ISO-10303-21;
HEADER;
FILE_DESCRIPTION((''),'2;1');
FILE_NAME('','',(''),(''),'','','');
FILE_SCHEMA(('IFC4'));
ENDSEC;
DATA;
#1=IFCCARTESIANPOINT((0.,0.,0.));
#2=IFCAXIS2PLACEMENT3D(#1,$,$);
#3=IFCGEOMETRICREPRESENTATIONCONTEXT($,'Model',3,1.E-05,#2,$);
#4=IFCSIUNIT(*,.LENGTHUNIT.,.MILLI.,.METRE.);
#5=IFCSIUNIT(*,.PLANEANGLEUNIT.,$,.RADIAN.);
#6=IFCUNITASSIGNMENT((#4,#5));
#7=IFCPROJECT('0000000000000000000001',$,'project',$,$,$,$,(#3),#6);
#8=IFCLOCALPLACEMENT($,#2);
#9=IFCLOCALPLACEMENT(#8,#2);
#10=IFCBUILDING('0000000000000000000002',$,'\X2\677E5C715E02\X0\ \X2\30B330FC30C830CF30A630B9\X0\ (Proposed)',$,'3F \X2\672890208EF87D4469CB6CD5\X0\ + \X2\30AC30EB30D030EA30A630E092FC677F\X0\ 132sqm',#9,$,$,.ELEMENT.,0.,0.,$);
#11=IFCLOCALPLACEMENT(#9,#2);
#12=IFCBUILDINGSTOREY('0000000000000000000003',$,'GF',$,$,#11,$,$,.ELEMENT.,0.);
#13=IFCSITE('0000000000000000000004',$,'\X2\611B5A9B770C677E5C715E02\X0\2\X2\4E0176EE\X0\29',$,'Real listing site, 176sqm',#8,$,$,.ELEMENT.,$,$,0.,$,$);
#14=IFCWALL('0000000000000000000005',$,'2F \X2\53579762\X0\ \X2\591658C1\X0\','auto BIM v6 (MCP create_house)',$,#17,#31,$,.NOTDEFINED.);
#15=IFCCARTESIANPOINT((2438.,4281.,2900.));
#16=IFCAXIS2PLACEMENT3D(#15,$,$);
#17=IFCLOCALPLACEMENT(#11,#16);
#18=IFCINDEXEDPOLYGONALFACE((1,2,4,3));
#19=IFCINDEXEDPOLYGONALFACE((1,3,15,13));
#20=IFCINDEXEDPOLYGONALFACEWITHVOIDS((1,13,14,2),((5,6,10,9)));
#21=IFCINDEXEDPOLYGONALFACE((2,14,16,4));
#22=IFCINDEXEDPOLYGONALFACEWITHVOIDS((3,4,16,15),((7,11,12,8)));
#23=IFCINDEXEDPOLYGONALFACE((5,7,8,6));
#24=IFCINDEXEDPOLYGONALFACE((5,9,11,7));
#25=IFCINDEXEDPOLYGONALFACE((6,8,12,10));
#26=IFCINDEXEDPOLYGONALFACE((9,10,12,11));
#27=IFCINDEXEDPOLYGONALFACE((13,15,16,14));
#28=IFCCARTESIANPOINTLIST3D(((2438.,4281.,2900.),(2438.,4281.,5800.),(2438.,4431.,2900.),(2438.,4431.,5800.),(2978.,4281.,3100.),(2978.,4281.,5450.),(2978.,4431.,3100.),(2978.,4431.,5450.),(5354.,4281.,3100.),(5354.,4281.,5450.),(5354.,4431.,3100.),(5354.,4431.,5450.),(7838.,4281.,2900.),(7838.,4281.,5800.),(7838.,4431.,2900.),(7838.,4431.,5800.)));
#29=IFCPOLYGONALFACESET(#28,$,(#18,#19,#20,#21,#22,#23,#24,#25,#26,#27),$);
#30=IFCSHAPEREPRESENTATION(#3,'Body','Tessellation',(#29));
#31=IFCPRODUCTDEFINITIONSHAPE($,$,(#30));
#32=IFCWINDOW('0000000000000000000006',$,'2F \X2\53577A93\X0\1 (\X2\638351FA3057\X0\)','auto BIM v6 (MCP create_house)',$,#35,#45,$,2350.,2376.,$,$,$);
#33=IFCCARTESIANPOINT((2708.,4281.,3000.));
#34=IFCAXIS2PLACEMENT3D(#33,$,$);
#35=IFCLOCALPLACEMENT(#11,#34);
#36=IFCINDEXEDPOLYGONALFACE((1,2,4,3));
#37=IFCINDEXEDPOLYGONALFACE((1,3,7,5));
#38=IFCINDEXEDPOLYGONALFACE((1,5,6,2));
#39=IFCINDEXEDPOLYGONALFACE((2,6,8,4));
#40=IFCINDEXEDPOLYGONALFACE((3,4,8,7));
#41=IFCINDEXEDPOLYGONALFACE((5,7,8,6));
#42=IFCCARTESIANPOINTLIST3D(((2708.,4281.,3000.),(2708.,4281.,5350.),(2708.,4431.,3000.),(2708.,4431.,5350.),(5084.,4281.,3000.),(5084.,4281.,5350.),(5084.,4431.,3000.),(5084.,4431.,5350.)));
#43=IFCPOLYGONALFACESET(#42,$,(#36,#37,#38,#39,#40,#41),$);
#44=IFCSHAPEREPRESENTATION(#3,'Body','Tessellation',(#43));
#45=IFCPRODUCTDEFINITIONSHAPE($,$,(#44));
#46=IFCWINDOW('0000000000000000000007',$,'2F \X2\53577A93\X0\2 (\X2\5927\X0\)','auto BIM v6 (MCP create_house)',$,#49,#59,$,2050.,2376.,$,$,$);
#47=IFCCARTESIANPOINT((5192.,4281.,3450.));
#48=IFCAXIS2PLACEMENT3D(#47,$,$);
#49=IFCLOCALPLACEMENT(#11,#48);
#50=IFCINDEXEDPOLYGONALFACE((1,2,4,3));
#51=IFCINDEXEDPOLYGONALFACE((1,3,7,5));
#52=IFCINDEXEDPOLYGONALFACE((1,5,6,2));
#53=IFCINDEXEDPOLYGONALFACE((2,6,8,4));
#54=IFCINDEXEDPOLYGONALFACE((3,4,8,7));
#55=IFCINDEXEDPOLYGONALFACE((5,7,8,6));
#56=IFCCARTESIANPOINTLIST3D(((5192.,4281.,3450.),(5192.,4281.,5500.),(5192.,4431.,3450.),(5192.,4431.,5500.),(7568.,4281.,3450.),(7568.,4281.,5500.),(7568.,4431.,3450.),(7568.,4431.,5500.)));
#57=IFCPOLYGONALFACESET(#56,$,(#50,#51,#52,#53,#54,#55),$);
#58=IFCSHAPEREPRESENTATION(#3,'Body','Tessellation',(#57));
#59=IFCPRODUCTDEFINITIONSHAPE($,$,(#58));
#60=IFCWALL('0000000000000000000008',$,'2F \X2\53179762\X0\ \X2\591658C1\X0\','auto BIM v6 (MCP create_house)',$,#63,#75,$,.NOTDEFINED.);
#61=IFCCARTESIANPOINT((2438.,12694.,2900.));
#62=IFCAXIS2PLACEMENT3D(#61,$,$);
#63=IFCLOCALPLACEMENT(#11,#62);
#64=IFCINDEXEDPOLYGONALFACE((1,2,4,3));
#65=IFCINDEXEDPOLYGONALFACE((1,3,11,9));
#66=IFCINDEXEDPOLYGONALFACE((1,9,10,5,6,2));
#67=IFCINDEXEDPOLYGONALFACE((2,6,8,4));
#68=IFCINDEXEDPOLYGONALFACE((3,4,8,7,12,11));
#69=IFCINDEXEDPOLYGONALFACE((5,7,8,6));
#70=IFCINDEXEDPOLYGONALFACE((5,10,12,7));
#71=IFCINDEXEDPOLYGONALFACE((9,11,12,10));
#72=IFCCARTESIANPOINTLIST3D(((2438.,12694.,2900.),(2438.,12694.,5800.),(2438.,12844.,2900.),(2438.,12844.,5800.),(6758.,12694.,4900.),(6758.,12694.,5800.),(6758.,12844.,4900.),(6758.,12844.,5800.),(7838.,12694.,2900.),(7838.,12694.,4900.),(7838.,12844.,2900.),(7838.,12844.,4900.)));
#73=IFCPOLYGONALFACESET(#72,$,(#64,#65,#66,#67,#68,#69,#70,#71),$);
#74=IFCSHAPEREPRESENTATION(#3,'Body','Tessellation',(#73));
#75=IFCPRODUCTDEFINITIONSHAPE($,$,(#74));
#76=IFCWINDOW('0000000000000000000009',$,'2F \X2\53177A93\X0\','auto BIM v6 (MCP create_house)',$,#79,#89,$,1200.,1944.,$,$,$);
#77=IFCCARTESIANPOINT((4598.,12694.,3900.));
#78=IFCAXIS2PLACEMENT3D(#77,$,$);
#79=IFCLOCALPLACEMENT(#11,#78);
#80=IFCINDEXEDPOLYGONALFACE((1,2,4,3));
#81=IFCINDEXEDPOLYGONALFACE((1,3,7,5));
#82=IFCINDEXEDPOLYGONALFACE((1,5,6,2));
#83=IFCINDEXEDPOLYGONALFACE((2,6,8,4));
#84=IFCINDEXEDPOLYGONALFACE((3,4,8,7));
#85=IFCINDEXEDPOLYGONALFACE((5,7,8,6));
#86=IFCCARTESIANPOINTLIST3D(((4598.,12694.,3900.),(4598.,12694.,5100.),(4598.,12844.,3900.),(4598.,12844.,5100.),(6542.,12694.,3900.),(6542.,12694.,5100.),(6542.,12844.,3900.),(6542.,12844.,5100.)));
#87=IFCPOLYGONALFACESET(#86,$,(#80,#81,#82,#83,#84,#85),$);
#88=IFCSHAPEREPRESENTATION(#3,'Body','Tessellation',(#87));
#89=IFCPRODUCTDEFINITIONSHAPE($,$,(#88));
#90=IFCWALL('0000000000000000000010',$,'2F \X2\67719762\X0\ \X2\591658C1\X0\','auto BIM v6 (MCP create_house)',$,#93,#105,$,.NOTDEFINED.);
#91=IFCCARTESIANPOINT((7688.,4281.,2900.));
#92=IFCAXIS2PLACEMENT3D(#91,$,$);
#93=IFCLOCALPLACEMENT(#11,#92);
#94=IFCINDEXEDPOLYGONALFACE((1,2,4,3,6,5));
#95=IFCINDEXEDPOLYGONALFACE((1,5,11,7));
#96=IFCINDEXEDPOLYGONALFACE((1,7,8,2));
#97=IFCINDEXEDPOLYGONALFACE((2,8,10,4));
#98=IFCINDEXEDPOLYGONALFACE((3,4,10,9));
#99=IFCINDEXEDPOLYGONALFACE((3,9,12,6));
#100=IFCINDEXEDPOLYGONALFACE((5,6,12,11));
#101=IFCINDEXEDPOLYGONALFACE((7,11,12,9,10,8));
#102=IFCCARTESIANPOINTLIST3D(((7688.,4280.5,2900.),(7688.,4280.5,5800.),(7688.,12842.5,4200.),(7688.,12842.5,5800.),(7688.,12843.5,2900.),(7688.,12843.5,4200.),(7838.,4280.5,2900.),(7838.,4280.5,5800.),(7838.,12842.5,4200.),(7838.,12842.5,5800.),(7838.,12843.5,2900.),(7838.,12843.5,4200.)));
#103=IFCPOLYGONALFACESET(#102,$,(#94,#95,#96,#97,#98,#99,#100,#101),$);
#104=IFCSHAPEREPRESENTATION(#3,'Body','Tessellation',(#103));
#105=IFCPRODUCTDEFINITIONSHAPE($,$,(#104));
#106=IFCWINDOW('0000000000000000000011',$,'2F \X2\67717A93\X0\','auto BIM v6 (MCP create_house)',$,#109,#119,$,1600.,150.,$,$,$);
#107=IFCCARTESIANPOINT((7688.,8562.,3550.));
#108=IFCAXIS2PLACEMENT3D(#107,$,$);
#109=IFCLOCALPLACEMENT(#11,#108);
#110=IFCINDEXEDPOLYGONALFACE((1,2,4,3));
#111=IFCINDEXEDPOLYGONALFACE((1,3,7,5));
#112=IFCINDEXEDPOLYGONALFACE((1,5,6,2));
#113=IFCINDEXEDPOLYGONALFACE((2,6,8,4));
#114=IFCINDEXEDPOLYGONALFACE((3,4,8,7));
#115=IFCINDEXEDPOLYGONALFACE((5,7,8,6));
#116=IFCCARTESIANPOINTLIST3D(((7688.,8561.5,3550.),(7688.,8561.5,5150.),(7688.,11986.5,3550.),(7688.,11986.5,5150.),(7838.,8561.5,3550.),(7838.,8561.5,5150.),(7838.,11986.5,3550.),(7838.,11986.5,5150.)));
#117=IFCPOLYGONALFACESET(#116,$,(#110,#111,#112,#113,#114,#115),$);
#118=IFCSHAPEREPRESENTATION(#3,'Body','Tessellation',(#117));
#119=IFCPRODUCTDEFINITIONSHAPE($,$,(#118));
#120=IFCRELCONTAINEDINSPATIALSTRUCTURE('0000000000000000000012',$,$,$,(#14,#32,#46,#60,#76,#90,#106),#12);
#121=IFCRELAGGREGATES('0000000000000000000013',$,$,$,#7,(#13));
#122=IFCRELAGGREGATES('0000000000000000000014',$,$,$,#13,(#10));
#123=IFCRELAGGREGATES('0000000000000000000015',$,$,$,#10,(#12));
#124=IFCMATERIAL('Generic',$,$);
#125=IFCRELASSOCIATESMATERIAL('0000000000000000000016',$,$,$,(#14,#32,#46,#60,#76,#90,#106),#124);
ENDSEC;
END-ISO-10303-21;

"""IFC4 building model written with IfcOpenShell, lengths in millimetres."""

from ifc_helpers import new_model, si_unit, frame, frame_2d, origin, place, context, project, spatial, rectangle, extrude, material, element, fill, save


model = new_model("IFC4")

# Units and contexts
model_context = context("Model", 3, precision=1e-05, world=origin())
ifc_project = project(units=[si_unit("LENGTHUNIT", "METRE", prefix="MILLI"), si_unit("PLANEANGLEUNIT", "RADIAN")], contexts=[model_context])

# Site, building, storey
site_placement = place(None, origin())
site = spatial("IfcSite", under=ifc_project, at=site_placement, Name="愛媛県松山市2丁目29", ObjectType="Real listing site, 176sqm", CompositionType="ELEMENT", RefElevation=0.0)
building_placement = place(site_placement, origin())
building = spatial("IfcBuilding", under=site, at=building_placement, Name="松山市 コートハウス (Proposed)", ObjectType="3F 木造軸組構法 + ガルバリウム鋼板 132sqm", CompositionType="ELEMENT", ElevationOfRefHeight=0.0, ElevationOfTerrain=0.0)
storey_placement = place(building_placement, origin())
storey = spatial("IfcBuildingStorey", under=building, at=storey_placement, Name="GF", CompositionType="ELEMENT", Elevation=0.0)

# Shared definitions
ifc_material = material(Name="Generic")

# Wall, openings, windows
wall_1_placement = place(storey_placement, frame((2438.0, 4281.0, 2900.0)))
wall_1 = element("IfcWall", 1, at=wall_1_placement, inside=storey, material=ifc_material, Name="2F 南面 外壁", Description="auto BIM v6 (MCP create_house)", PredefinedType="NOTDEFINED", context=model_context, shape_type="SweptSolid", body=[
    extrude(rectangle(XDim=5400.0, YDim=150.0, at=frame_2d((2700.0, 75.0))), frame((2438.0, 4281.0, 2900.0)), (0.0, 0.0, 1.0), 2900.0),
])
opening_1_placement = place(storey_placement, frame((2708.0, 4281.0, 3000.0)))
opening_1 = element("IfcOpeningElement", 2, at=opening_1_placement, cuts=wall_1, PredefinedType="NOTDEFINED", context=model_context, shape_type="SweptSolid", body=[
    extrude(rectangle(XDim=2376.0, YDim=150.0, at=frame_2d((1188.0, 75.0))), frame((2708.0, 4281.0, 3000.0)), (0.0, 0.0, 1.0), 2350.0),
])
opening_2_placement = place(storey_placement, frame((5192.0, 4281.0, 3450.0)))
opening_2 = element("IfcOpeningElement", 3, at=opening_2_placement, cuts=wall_1, PredefinedType="NOTDEFINED", context=model_context, shape_type="SweptSolid", body=[
    extrude(rectangle(XDim=2376.0, YDim=150.0, at=frame_2d((1188.0, 75.0))), frame((5192.0, 4281.0, 3450.0)), (0.0, 0.0, 1.0), 2050.0),
])
window_1_placement = place(storey_placement, frame((2708.0, 4281.0, 3000.0)))
window_1 = element("IfcWindow", 4, at=window_1_placement, inside=storey, material=ifc_material, Name="2F 南窓1 (掃出し)", Description="auto BIM v6 (MCP create_house)", OverallHeight=2350.0, OverallWidth=2376.0, context=model_context, shape_type="SweptSolid", body=[
    extrude(rectangle(XDim=2376.0, YDim=150.0, at=frame_2d((1188.0, 75.0))), frame((2708.0, 4281.0, 3000.0)), (0.0, 0.0, 1.0), 2350.0),
])
fill(opening_1, window_1)
window_2_placement = place(storey_placement, frame((5192.0, 4281.0, 3450.0)))
window_2 = element("IfcWindow", 5, at=window_2_placement, inside=storey, material=ifc_material, Name="2F 南窓2 (大)", Description="auto BIM v6 (MCP create_house)", OverallHeight=2050.0, OverallWidth=2376.0, context=model_context, shape_type="SweptSolid", body=[
    extrude(rectangle(XDim=2376.0, YDim=150.0, at=frame_2d((1188.0, 75.0))), frame((5192.0, 4281.0, 3450.0)), (0.0, 0.0, 1.0), 2050.0),
])
fill(opening_2, window_2)

# Walls, openings, windows
wall_2_placement = place(storey_placement, frame((2438.0, 12694.0, 2900.0)))
wall_2 = element("IfcWall", 6, at=wall_2_placement, inside=storey, material=ifc_material, Name="2F 北面 外壁", Description="auto BIM v6 (MCP create_house)", PredefinedType="NOTDEFINED", context=model_context, shape_type="SweptSolid", body=[
    extrude(rectangle(XDim=5400.0, YDim=150.0, at=frame_2d((2700.0, 75.0))), frame((2438.0, 12694.0, 2900.0)), (0.0, 0.0, 1.0), 2900.0),
])
opening_3_placement = place(storey_placement, frame((4598.0, 12694.0, 3900.0)))
opening_3 = element("IfcOpeningElement", 7, at=opening_3_placement, cuts=wall_2, PredefinedType="NOTDEFINED", context=model_context, shape_type="SweptSolid", body=[
    extrude(rectangle(XDim=1944.0, YDim=150.0, at=frame_2d((972.0, 75.0))), frame((4598.0, 12694.0, 3900.0)), (0.0, 0.0, 1.0), 1200.0),
])
window_3_placement = place(storey_placement, frame((4598.0, 12694.0, 3900.0)))
window_3 = element("IfcWindow", 8, at=window_3_placement, inside=storey, material=ifc_material, Name="2F 北窓", Description="auto BIM v6 (MCP create_house)", OverallHeight=1200.0, OverallWidth=1944.0, context=model_context, shape_type="SweptSolid", body=[
    extrude(rectangle(XDim=1944.0, YDim=150.0, at=frame_2d((972.0, 75.0))), frame((4598.0, 12694.0, 3900.0)), (0.0, 0.0, 1.0), 1200.0),
])
fill(opening_3, window_3)
wall_3_placement = place(storey_placement, frame((7688.0, 4281.0, 2900.0)))
wall_3 = element("IfcWall", 9, at=wall_3_placement, inside=storey, material=ifc_material, Name="2F 東面 外壁", Description="auto BIM v6 (MCP create_house)", PredefinedType="NOTDEFINED", context=model_context, shape_type="SweptSolid", body=[
    extrude(rectangle(XDim=150.0, YDim=8563.0, at=frame_2d((75.0, 4281.0))), frame((7688.0, 4281.0, 2900.0)), (0.0, 0.0, 1.0), 2900.0),
])
opening_4_placement = place(storey_placement, frame((7688.0, 8562.0, 3550.0)))
opening_4 = element("IfcOpeningElement", 10, at=opening_4_placement, cuts=wall_3, PredefinedType="NOTDEFINED", context=model_context, shape_type="SweptSolid", body=[
    extrude(rectangle(XDim=150.0, YDim=3425.0, at=frame_2d((75.0, 1712.0))), frame((7688.0, 8562.0, 3550.0)), (0.0, 0.0, 1.0), 1600.0),
])
window_4_placement = place(storey_placement, frame((7688.0, 8562.0, 3550.0)))
window_4 = element("IfcWindow", 11, at=window_4_placement, inside=storey, material=ifc_material, Name="2F 東窓", Description="auto BIM v6 (MCP create_house)", OverallHeight=1600.0, OverallWidth=150.0, context=model_context, shape_type="SweptSolid", body=[
    extrude(rectangle(XDim=150.0, YDim=3425.0, at=frame_2d((75.0, 1712.0))), frame((7688.0, 8562.0, 3550.0)), (0.0, 0.0, 1.0), 1600.0),
])
fill(opening_4, window_4)

save(model, "model.ifc")
